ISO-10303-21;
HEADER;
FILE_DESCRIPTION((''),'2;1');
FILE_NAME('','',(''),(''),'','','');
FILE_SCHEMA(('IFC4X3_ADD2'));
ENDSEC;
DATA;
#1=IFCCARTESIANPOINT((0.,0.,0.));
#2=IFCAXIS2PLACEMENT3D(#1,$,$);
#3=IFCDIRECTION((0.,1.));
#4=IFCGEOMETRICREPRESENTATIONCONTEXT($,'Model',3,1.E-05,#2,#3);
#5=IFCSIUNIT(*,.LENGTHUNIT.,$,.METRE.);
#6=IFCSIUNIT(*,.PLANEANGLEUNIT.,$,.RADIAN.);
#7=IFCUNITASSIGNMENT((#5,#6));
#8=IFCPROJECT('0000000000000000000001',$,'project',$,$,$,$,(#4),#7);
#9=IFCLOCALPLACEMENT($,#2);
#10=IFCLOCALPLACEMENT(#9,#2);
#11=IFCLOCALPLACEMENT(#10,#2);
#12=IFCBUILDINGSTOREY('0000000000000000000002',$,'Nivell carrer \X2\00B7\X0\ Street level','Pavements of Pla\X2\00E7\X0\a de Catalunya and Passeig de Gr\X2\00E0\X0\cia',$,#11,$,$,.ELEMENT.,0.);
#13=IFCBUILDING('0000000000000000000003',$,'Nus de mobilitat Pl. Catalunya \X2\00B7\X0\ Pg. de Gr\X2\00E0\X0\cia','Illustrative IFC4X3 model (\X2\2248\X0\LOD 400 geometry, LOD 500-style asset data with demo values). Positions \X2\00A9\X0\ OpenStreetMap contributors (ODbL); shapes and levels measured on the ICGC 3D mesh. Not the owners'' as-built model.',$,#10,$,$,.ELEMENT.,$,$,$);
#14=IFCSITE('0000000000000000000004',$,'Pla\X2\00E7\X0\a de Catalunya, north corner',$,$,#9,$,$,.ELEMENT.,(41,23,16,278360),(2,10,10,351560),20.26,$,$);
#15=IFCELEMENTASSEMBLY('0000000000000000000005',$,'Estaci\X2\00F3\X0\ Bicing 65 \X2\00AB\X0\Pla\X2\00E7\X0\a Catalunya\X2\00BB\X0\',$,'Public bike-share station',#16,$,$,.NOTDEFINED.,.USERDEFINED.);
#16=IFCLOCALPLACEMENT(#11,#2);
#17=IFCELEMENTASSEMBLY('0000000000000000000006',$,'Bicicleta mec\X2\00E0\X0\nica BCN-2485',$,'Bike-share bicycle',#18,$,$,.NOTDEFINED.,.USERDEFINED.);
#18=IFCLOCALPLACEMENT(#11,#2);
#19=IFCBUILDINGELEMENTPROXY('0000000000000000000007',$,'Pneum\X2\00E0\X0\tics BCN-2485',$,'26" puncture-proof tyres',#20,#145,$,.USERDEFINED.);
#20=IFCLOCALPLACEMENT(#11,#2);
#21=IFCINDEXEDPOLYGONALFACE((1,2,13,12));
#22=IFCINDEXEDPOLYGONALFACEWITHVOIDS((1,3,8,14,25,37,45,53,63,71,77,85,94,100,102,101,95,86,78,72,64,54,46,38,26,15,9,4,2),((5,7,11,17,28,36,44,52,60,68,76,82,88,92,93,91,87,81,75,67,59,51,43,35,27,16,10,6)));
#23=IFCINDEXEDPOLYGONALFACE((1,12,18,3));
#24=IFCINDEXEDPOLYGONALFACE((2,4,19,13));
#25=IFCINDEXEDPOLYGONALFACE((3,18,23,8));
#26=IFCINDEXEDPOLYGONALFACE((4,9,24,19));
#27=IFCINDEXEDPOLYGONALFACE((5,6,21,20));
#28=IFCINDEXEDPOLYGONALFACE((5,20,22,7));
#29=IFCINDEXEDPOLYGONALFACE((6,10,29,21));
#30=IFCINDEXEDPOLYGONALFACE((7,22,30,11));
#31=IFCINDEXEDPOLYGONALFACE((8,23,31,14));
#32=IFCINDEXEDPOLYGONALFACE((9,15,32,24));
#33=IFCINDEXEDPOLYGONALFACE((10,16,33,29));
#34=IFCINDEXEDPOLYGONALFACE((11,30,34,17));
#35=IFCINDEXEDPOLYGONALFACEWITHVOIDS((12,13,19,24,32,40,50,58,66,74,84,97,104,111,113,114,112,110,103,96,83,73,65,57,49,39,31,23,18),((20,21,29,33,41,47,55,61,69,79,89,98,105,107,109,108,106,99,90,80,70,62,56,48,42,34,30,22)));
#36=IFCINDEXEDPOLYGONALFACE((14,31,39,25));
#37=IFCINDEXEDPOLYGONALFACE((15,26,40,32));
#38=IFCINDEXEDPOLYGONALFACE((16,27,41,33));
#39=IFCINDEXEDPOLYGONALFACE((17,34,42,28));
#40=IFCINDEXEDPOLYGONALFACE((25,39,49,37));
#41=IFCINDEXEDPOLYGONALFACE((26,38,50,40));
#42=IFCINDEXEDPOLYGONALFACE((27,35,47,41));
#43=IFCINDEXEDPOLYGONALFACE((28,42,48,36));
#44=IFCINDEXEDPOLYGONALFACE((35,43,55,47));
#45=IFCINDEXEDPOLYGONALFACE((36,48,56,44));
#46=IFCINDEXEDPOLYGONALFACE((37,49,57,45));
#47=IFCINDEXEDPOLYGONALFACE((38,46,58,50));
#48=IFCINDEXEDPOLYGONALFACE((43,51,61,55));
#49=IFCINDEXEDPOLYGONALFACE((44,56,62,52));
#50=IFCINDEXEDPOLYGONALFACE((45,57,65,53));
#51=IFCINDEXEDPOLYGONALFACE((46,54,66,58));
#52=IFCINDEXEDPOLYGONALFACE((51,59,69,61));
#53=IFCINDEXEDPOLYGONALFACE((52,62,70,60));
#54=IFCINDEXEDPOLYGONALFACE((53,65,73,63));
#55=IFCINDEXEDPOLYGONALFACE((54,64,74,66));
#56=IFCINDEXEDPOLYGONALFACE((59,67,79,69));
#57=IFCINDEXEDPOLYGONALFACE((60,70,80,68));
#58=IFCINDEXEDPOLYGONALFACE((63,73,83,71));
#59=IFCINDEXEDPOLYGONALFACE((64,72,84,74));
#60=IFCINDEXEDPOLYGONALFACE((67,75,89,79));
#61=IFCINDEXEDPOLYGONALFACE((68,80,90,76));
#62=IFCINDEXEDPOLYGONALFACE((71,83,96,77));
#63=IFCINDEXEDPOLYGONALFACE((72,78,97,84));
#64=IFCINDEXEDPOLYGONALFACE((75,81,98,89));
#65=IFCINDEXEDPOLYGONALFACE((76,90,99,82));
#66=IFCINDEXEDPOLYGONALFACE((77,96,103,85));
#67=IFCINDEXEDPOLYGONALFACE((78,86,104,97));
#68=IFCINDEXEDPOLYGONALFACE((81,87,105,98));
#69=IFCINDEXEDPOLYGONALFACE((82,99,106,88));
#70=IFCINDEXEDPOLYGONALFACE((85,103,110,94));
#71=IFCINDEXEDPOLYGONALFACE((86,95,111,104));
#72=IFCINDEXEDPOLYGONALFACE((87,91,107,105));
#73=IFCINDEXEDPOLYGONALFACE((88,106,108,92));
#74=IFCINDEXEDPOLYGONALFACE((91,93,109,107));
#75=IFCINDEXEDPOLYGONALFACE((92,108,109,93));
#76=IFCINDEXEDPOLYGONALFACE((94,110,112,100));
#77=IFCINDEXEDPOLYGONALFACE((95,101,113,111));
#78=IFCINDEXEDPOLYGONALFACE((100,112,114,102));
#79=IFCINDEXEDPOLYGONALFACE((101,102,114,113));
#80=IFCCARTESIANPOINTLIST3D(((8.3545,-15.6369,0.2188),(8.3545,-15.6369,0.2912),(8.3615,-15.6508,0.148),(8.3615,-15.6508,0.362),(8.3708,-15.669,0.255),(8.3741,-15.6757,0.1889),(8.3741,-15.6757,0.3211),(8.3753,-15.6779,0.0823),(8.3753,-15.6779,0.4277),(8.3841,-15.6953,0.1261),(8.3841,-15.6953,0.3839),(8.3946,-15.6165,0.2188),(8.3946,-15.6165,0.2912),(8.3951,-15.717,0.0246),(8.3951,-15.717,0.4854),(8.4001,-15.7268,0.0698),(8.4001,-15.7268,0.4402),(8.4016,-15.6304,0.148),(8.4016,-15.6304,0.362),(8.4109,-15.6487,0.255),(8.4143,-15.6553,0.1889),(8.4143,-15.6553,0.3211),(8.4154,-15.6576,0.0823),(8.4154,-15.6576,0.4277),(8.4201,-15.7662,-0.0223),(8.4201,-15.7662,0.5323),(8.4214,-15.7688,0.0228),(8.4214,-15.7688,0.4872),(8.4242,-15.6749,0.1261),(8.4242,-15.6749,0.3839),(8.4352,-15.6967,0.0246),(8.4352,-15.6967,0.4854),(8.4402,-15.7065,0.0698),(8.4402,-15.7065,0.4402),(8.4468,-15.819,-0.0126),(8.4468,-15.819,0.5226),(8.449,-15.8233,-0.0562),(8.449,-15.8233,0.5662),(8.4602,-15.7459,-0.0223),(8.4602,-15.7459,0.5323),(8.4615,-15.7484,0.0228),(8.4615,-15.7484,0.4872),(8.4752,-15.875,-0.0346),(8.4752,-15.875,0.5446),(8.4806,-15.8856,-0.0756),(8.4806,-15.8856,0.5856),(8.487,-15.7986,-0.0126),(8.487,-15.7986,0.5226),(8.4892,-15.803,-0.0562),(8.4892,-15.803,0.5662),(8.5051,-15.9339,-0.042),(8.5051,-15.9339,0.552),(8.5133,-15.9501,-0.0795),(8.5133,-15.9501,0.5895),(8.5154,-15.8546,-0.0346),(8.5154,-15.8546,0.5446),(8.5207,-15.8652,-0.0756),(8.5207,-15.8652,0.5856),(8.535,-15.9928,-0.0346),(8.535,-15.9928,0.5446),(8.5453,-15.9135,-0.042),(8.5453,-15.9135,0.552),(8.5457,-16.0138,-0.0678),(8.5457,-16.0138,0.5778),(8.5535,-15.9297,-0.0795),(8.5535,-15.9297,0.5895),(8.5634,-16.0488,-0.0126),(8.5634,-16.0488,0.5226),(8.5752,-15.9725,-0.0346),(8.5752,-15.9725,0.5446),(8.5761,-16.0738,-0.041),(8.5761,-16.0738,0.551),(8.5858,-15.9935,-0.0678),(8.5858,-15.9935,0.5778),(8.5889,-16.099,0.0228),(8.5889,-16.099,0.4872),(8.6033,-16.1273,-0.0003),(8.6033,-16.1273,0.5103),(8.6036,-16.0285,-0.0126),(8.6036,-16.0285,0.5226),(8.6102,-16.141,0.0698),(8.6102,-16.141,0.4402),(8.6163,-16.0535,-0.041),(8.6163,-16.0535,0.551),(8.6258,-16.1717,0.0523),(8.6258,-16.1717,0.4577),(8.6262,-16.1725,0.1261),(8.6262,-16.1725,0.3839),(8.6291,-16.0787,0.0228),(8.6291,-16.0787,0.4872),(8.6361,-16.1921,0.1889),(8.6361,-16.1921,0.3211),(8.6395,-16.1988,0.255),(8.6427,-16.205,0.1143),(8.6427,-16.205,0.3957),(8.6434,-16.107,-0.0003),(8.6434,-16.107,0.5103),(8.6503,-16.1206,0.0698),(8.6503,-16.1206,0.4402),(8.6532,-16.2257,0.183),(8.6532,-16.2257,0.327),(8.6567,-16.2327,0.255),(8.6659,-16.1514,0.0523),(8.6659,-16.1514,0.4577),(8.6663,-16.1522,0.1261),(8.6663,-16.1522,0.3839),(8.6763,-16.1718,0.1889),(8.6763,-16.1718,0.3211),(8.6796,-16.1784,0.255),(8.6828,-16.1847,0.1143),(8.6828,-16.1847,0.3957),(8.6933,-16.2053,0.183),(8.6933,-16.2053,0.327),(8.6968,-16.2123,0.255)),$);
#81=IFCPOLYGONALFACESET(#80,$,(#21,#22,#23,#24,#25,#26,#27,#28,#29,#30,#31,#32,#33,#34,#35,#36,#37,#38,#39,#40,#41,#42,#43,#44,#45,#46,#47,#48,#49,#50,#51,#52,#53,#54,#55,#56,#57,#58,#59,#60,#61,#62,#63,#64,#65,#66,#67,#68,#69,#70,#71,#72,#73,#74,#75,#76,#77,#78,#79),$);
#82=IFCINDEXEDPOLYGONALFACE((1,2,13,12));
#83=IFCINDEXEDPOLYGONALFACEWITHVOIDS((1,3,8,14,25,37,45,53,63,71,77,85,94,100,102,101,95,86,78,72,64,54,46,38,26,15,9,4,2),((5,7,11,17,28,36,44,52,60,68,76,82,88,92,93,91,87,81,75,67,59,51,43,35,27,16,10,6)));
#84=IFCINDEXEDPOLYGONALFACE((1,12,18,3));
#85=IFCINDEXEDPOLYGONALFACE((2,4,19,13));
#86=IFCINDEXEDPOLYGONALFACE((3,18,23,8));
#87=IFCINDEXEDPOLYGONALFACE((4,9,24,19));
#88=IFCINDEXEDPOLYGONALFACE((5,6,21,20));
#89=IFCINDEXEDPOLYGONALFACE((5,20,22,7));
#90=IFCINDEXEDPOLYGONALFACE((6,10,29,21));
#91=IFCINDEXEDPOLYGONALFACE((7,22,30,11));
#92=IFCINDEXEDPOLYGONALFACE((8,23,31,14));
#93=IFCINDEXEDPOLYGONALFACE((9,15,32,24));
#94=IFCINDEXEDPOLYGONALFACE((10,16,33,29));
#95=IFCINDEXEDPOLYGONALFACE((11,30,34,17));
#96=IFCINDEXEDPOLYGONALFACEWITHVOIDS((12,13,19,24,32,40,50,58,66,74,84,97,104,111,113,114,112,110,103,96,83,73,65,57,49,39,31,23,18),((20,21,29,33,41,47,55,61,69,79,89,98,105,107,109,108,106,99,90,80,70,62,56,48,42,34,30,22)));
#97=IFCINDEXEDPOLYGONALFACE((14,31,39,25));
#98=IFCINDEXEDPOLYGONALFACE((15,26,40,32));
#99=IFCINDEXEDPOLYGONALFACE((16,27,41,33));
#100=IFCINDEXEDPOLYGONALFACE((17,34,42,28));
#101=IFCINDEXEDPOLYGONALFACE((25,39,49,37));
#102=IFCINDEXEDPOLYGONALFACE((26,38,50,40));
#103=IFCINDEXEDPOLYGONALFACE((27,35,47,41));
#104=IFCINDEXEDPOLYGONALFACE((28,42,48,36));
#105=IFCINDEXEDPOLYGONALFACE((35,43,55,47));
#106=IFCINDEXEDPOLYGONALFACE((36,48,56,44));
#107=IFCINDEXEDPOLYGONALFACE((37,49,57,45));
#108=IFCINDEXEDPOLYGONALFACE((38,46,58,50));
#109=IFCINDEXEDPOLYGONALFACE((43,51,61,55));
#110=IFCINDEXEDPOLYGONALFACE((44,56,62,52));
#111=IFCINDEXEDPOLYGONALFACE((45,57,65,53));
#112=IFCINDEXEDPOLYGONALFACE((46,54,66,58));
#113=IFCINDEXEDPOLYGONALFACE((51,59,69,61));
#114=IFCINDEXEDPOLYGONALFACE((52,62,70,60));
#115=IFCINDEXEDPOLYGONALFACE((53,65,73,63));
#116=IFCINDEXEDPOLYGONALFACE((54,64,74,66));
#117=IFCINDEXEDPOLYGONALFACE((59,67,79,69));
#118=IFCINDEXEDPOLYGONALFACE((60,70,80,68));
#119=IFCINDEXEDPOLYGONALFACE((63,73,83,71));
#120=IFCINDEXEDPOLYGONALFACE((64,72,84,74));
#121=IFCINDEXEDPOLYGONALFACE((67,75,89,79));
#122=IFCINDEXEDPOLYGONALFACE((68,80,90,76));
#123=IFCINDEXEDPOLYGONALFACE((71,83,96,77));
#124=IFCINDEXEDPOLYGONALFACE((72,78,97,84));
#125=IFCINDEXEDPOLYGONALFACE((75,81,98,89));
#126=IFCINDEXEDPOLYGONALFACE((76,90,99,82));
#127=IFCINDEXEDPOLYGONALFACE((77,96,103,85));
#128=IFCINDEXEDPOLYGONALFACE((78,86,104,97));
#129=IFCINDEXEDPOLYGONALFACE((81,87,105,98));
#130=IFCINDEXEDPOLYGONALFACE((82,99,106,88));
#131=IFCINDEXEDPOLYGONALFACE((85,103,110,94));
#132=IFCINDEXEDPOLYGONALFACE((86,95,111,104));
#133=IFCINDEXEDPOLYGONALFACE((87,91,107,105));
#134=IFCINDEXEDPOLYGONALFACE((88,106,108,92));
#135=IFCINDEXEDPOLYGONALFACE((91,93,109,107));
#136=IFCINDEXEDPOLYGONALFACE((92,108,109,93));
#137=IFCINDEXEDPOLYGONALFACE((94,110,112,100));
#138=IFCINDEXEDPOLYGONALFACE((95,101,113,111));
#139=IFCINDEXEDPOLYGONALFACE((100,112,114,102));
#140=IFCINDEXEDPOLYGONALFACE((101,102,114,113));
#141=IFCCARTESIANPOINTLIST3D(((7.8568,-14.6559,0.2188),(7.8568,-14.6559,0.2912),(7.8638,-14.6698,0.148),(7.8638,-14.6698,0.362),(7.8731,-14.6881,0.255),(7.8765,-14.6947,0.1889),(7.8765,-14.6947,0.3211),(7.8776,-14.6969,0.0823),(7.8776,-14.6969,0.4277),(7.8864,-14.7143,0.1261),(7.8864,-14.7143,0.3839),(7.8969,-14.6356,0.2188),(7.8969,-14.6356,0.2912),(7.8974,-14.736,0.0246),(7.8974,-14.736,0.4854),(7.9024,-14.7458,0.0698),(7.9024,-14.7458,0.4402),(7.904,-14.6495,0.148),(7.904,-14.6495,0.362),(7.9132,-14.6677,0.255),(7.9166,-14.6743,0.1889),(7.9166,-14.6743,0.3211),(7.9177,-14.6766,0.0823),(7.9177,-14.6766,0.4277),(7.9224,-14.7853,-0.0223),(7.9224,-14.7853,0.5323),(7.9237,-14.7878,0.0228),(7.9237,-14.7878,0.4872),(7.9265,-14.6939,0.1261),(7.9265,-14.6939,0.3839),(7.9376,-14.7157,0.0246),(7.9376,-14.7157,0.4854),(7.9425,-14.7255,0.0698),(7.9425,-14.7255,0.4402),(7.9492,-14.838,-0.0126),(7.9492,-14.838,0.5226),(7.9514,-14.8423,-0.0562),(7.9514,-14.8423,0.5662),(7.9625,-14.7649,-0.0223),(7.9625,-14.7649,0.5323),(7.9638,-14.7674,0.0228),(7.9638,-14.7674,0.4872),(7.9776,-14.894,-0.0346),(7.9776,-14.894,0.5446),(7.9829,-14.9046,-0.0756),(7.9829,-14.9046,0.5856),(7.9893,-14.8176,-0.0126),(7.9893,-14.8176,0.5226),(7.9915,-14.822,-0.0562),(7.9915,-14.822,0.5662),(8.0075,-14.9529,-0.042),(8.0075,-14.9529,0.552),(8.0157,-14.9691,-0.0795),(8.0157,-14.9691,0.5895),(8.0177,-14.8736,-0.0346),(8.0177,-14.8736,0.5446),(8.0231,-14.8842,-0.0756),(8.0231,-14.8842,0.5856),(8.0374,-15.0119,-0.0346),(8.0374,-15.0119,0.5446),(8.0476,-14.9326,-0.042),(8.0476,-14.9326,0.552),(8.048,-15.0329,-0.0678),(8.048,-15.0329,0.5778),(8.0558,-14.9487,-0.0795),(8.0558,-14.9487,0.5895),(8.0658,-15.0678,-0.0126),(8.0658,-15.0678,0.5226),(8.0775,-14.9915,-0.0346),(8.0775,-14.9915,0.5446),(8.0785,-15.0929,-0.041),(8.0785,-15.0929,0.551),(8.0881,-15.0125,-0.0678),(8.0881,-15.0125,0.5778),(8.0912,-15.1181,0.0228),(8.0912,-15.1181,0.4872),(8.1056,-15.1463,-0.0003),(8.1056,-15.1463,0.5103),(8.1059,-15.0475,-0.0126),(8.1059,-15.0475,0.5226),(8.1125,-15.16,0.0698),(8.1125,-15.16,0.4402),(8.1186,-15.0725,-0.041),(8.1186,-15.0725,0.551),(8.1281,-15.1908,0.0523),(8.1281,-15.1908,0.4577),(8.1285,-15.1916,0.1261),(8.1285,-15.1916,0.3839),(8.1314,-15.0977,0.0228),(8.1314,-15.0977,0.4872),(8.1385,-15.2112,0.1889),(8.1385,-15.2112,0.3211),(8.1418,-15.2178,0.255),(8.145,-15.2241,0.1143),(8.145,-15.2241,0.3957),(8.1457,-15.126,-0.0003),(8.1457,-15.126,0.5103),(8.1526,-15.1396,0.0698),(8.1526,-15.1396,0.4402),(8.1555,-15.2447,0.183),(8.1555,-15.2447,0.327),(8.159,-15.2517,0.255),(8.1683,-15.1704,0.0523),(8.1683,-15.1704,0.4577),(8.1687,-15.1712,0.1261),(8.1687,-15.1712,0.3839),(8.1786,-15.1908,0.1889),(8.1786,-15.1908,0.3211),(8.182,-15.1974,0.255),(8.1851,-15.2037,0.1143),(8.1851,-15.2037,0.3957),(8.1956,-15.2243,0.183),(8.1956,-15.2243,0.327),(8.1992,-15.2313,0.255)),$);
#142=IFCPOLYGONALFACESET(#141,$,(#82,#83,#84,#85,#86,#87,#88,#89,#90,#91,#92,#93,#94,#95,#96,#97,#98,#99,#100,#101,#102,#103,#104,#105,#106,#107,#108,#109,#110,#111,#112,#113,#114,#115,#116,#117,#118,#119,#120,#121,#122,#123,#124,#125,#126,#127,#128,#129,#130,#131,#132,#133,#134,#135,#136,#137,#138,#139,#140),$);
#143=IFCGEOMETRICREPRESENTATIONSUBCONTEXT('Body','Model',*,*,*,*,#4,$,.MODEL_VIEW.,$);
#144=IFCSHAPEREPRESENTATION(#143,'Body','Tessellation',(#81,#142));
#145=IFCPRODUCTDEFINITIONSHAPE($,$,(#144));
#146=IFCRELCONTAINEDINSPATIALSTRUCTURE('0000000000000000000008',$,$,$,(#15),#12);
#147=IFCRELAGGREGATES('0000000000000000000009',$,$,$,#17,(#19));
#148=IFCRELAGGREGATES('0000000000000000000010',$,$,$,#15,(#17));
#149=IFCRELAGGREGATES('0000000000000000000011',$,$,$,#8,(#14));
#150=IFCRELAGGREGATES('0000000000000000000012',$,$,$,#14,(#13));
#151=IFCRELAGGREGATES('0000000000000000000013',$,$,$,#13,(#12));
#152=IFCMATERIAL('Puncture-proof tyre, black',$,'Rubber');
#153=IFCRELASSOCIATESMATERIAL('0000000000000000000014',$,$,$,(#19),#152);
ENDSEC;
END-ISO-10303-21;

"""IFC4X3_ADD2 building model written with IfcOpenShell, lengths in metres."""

from ifc_helpers import new_model, si_unit, direction, frame, origin, origin_2d_with_axis, place, context, subcontext, project, spatial, hollow_circle, extrude, material, element, aggregate, save


model = new_model("IFC4X3_ADD2")

# Units and contexts
model_context = context("Model", 3, precision=1e-05, world=origin(), true_north=direction((0.0, 1.0)))
body_context = subcontext(model_context, "Body", "Model", "MODEL_VIEW")
ifc_project = project(units=[si_unit("LENGTHUNIT", "METRE"), si_unit("PLANEANGLEUNIT", "RADIAN")], contexts=[model_context])

# Site, building, storey
site_placement = place(None, origin())
site = spatial("IfcSite", under=ifc_project, at=site_placement, Name="Plaça de Catalunya, north corner", CompositionType="ELEMENT", RefLatitude=(41, 23, 16, 278360), RefLongitude=(2, 10, 10, 351560), RefElevation=20.26)
building_placement = place(site_placement, origin())
building = spatial("IfcBuilding", under=site, at=building_placement, Name="Nus de mobilitat Pl. Catalunya · Pg. de Gràcia", Description="Illustrative IFC4X3 model (≈LOD 400 geometry, LOD 500-style asset data with demo values). Positions © OpenStreetMap contributors (ODbL); shapes and levels measured on the ICGC 3D mesh. Not the owners' as-built model.", CompositionType="ELEMENT")
storey_placement = place(building_placement, origin())
storey = spatial("IfcBuildingStorey", under=building, at=storey_placement, Name="Nivell carrer · Street level", Description="Pavements of Plaça de Catalunya and Passeig de Gràcia", CompositionType="ELEMENT", Elevation=0.0)

# Element assemblies, building element proxy
assembly_1_placement = place(building_placement, origin())
assembly_1 = element("IfcElementAssembly", 1, at=assembly_1_placement, inside=storey, Name="Estació Bicing 65 «Plaça Catalunya»", ObjectType="Public bike-share station", AssemblyPlace="NOTDEFINED", PredefinedType="USERDEFINED")
assembly_2_placement = place(building_placement, origin())
assembly_2 = element("IfcElementAssembly", 2, at=assembly_2_placement, Name="Bicicleta mecànica BCN-2485", ObjectType="Bike-share bicycle", AssemblyPlace="NOTDEFINED", PredefinedType="USERDEFINED")
ifc_material_1 = material(Name="Puncture-proof tyre, black", Category="Rubber")
proxy_1_placement = place(building_placement, origin())
proxy_1 = element("IfcBuildingElementProxy", 3, at=proxy_1_placement, material=ifc_material_1, Name="Pneumàtics BCN-2485", ObjectType="26\" puncture-proof tyres", PredefinedType="USERDEFINED", context=body_context, shape_type="SweptSolid", body=[
    extrude(hollow_circle(Radius=0.335, WallThickness=0.038, at=origin_2d_with_axis()), frame((8.5051, -15.9339, 0.255), z_axis=(0.891798, 0.452435, 0.0), x_axis=(0.452435, -0.891798, 0.0)), (0.0, 0.0, 1.0), 0.045),
    extrude(hollow_circle(Radius=0.335, WallThickness=0.038, at=origin_2d_with_axis()), frame((8.0075, -14.9529, 0.255), z_axis=(0.891798, 0.452435, 0.0), x_axis=(0.452435, -0.891798, 0.0)), (0.0, 0.0, 1.0), 0.045),
])
aggregate(assembly_2, [proxy_1])
aggregate(assembly_1, [assembly_2])

save(model, "model.ifc")
